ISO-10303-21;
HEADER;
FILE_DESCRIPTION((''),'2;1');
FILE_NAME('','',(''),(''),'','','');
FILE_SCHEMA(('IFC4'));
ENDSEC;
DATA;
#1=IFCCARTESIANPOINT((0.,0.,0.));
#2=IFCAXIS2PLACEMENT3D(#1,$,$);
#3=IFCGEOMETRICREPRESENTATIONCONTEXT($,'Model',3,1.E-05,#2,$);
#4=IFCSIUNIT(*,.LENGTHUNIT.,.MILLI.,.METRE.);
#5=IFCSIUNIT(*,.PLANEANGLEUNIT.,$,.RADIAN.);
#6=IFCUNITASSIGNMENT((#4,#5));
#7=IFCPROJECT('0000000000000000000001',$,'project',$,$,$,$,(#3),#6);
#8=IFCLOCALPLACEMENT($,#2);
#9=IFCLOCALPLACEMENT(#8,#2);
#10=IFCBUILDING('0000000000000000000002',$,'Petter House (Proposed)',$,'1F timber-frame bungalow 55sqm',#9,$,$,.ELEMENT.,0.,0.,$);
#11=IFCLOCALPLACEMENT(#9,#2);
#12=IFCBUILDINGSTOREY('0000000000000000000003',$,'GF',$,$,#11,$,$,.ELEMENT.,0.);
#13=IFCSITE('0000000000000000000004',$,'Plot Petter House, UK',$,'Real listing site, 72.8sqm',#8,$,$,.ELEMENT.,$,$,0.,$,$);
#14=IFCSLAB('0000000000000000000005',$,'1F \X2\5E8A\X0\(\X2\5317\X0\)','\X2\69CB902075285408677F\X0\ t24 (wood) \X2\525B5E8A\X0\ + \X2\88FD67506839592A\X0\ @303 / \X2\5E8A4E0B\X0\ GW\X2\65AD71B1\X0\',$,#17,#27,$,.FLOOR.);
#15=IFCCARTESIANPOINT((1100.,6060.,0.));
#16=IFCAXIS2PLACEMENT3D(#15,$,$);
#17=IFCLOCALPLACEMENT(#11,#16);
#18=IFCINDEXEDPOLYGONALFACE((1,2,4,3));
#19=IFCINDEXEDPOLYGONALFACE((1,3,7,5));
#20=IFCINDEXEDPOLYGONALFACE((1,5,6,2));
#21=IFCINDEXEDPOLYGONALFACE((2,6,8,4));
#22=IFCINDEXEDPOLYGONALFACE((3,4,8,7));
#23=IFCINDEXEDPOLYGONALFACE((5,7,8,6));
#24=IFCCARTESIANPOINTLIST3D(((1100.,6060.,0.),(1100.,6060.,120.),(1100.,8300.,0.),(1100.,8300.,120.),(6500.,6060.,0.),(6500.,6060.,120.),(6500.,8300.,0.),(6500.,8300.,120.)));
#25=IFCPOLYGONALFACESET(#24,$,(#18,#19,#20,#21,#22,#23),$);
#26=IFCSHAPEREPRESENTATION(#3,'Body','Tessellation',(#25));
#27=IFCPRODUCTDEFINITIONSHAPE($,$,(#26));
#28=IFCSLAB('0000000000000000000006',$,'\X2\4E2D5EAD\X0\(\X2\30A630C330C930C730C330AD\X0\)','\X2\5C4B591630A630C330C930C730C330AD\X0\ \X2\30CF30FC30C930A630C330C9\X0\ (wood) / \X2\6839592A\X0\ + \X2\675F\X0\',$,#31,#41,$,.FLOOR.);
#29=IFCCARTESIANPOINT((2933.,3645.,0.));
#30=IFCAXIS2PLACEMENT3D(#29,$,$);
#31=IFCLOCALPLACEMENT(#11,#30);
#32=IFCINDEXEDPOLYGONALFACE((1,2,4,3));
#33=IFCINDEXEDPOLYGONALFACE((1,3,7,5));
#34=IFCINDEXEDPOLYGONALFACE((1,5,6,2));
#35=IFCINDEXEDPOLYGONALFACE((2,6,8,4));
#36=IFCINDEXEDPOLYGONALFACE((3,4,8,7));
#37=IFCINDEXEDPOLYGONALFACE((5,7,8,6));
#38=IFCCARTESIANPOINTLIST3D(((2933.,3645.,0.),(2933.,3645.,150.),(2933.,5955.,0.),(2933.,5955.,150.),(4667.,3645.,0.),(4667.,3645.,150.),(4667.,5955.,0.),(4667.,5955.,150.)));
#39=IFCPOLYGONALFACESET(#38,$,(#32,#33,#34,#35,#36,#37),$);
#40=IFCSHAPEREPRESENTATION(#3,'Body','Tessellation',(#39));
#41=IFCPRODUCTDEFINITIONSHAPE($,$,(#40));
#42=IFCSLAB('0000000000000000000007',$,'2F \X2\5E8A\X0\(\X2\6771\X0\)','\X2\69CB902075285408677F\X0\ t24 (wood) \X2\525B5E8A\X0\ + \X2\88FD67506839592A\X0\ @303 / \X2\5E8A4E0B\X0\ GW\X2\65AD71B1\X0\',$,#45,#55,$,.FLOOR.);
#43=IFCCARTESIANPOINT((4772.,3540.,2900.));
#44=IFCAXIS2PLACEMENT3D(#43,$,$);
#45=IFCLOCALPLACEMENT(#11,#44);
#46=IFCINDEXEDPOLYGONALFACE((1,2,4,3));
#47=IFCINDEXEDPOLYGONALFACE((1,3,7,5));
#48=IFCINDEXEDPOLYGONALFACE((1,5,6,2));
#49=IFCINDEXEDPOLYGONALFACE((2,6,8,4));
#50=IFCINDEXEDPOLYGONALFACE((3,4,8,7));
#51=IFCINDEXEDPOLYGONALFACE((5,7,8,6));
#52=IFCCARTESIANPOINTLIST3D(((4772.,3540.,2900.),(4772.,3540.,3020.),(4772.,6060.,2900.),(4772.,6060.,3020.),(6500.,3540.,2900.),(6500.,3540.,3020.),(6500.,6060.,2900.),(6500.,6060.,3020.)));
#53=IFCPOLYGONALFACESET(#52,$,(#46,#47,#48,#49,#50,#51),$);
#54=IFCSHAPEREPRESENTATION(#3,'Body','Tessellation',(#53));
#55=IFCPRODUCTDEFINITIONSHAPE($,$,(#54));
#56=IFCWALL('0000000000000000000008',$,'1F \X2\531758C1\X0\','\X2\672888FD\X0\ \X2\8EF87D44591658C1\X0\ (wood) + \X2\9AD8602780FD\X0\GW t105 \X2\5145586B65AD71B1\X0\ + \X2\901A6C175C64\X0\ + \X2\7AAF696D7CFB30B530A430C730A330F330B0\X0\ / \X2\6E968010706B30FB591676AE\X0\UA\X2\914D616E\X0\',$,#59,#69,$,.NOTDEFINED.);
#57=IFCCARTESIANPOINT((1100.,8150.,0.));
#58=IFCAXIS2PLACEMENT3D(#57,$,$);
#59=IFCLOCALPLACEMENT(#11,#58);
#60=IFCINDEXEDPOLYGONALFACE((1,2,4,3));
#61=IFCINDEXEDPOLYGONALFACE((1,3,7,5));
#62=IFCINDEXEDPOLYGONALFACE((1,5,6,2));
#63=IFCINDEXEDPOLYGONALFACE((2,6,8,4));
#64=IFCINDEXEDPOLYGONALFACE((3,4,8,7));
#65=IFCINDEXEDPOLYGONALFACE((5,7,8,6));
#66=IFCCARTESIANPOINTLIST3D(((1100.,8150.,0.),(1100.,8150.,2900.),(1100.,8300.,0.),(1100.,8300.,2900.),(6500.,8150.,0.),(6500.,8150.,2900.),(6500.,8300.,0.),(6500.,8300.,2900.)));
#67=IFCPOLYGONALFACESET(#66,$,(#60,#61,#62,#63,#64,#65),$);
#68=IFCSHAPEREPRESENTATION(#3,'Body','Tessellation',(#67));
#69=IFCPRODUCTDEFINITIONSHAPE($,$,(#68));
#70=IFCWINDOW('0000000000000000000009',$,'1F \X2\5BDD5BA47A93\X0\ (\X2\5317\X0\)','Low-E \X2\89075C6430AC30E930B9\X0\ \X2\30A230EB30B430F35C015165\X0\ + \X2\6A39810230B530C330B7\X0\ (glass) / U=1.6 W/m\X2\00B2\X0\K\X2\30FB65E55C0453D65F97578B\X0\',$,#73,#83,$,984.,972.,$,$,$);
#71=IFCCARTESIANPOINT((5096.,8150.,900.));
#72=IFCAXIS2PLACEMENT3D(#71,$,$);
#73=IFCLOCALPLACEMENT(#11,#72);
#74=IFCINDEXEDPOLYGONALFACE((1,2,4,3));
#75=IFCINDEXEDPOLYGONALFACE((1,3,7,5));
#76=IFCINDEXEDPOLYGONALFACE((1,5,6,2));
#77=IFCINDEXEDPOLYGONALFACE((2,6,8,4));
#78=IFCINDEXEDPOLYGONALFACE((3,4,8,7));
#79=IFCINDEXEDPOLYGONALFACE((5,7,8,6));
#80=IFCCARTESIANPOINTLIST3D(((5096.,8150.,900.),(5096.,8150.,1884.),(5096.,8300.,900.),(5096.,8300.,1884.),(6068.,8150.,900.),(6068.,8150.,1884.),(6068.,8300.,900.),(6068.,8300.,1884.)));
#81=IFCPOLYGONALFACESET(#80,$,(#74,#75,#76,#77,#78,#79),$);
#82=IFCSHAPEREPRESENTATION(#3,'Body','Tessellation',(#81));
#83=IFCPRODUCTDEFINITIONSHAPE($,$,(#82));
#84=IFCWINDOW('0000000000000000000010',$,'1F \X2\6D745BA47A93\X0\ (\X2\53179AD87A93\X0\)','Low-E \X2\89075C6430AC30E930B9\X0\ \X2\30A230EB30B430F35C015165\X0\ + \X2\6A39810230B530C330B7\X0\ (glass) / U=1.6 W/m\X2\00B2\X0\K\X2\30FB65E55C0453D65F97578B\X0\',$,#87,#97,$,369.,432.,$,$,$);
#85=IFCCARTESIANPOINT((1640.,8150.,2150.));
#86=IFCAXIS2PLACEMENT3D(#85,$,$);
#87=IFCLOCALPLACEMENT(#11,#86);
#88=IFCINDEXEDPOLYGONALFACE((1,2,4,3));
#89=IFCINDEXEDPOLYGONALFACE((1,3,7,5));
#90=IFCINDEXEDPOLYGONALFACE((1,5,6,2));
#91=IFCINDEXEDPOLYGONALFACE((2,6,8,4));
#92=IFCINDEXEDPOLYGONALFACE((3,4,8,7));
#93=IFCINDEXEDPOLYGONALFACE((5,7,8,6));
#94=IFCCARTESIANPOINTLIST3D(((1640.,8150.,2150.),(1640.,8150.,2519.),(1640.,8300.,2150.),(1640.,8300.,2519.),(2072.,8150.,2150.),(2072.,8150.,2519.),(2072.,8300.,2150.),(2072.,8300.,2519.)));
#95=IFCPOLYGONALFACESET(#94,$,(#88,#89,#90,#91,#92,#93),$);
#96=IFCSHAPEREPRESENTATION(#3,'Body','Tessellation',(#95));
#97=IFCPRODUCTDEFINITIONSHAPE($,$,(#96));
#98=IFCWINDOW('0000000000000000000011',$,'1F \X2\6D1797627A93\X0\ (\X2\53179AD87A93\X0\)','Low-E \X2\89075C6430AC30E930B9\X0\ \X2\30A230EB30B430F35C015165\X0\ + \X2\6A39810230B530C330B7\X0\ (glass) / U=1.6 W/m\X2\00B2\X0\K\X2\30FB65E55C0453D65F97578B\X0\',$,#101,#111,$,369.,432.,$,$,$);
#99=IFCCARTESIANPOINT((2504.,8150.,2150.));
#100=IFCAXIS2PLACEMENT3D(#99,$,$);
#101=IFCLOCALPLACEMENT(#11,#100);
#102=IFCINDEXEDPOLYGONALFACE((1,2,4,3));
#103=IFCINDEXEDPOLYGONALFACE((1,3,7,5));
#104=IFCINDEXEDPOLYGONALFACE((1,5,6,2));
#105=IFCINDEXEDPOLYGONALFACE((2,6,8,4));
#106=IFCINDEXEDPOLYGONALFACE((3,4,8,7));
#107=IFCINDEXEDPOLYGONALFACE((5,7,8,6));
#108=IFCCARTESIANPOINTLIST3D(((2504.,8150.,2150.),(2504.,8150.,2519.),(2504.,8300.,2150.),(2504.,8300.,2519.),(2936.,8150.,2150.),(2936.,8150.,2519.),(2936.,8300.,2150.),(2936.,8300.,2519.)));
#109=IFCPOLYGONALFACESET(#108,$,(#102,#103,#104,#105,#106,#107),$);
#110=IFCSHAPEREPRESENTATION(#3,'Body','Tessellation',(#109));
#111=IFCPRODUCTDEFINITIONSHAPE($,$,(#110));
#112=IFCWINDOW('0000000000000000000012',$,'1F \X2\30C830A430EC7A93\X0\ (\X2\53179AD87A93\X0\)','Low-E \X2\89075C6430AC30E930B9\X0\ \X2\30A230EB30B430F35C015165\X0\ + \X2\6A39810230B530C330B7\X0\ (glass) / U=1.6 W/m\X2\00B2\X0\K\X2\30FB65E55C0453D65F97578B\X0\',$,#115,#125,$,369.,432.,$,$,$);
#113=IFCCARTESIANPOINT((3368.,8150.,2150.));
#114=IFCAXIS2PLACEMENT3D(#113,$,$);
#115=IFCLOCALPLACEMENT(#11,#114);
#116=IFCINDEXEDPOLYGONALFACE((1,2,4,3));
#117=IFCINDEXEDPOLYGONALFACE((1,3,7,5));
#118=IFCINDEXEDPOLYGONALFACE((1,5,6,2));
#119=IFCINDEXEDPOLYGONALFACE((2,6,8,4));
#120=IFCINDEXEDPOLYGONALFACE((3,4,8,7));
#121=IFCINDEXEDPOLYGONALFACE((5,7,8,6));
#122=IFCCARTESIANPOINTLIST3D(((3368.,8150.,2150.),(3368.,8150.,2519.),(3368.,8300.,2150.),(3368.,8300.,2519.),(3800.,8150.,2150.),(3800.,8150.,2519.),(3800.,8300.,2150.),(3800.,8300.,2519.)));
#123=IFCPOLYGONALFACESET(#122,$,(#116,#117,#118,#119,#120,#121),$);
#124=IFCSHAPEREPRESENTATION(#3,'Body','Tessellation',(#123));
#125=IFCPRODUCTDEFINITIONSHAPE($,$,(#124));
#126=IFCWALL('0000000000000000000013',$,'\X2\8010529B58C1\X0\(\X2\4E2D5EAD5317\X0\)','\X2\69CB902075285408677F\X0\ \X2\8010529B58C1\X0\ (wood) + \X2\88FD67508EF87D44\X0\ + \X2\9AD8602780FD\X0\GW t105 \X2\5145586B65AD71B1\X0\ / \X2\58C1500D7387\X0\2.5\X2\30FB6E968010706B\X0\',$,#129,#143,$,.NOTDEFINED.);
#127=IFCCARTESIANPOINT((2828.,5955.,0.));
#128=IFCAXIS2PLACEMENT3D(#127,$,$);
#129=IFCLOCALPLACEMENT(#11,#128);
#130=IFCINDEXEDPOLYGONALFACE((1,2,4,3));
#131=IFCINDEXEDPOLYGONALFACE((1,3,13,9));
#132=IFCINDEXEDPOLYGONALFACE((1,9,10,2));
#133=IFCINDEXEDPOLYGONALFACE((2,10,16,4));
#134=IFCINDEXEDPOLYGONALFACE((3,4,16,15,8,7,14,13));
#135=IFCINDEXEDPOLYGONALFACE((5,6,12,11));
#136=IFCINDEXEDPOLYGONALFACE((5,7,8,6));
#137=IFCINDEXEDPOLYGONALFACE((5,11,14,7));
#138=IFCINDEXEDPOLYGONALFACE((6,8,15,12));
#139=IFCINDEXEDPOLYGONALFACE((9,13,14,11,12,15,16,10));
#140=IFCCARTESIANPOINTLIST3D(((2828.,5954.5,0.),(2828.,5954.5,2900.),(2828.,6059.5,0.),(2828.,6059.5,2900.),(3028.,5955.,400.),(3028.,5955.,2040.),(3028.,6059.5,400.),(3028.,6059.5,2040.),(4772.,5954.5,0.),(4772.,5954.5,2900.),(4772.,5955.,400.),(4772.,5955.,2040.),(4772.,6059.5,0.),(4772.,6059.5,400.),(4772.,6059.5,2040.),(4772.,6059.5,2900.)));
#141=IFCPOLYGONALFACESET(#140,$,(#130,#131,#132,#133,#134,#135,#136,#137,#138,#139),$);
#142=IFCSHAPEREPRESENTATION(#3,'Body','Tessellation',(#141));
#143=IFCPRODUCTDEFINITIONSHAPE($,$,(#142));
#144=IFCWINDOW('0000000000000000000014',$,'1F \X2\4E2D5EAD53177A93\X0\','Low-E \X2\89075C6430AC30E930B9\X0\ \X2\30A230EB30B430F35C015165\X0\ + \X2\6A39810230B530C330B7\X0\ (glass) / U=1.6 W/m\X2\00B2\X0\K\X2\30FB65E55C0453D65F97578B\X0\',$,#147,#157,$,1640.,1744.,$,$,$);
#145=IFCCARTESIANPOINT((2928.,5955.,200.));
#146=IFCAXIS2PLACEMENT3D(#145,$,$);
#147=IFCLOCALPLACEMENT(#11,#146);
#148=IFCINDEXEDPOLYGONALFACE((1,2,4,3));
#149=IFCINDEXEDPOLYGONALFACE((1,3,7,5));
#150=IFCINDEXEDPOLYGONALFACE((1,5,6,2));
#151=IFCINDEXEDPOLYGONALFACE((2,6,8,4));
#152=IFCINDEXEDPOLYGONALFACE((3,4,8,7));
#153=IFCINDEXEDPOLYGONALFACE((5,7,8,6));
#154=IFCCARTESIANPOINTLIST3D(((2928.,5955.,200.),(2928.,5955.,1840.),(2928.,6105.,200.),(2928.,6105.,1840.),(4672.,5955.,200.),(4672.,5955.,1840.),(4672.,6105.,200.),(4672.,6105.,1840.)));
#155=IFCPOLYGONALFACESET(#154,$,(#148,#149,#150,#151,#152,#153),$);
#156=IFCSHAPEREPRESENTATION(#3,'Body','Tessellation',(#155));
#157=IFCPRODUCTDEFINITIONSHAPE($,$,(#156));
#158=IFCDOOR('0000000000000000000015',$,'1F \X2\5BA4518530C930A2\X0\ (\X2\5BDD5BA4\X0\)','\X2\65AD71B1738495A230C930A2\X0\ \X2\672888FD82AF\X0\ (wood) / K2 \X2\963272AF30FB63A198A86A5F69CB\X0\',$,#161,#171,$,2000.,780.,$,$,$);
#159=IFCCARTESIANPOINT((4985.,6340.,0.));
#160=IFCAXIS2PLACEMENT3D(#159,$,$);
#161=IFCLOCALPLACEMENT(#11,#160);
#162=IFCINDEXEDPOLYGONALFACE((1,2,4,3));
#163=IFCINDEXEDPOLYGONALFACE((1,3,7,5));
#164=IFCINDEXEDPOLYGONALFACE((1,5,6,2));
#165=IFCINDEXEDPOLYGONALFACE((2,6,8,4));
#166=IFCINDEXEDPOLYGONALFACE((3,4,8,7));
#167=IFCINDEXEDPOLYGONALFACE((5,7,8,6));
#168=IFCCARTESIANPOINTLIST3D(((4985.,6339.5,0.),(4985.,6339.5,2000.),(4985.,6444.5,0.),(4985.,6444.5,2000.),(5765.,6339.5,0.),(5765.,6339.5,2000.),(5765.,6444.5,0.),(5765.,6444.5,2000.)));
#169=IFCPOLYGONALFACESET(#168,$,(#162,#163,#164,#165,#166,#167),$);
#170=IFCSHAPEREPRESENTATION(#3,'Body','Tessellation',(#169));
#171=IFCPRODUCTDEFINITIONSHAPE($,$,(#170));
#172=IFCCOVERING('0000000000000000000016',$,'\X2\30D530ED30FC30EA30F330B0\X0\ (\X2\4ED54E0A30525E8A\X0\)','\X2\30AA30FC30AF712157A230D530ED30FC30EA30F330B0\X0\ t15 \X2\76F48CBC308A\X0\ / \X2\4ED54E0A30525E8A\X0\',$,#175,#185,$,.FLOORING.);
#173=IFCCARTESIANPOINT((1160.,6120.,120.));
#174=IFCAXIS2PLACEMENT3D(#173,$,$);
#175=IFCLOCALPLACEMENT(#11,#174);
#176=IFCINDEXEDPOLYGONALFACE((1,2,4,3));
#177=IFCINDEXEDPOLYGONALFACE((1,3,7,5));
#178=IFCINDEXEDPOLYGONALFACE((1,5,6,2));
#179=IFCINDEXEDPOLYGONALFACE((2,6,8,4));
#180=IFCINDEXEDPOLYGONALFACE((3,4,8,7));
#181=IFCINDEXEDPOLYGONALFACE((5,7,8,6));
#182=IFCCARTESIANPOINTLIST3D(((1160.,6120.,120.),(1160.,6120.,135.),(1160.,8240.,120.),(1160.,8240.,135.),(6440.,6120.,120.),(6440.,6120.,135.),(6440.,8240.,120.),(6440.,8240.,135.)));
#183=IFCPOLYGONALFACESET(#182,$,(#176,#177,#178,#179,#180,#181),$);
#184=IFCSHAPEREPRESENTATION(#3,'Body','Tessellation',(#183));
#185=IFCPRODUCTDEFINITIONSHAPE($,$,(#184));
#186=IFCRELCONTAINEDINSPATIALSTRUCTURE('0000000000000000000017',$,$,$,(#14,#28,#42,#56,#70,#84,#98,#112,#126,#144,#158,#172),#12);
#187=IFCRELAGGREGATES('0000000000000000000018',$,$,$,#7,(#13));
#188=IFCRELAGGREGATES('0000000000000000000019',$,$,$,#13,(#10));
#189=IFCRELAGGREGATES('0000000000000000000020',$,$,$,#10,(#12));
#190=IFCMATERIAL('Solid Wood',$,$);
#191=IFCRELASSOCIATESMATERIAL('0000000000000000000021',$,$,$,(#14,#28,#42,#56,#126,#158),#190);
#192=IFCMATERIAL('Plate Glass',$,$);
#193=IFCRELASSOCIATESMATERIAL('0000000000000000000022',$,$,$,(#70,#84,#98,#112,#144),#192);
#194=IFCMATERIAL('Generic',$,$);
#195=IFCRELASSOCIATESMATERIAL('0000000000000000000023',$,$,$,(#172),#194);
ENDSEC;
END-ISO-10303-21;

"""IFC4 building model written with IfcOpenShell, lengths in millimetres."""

from ifc_helpers import new_model, si_unit, frame, frame_2d, origin, place, context, project, spatial, rectangle, extrude, material, element, fill, save


model = new_model("IFC4")

# Units and contexts
model_context = context("Model", 3, precision=1e-05, world=origin())
ifc_project = project(units=[si_unit("LENGTHUNIT", "METRE", prefix="MILLI"), si_unit("PLANEANGLEUNIT", "RADIAN")], contexts=[model_context])

# Site, building, storey
site_placement = place(None, origin())
site = spatial("IfcSite", under=ifc_project, at=site_placement, Name="Plot Petter House, UK", ObjectType="Real listing site, 72.8sqm", CompositionType="ELEMENT", RefElevation=0.0)
building_placement = place(site_placement, origin())
building = spatial("IfcBuilding", under=site, at=building_placement, Name="Petter House (Proposed)", ObjectType="1F timber-frame bungalow 55sqm", CompositionType="ELEMENT", ElevationOfRefHeight=0.0, ElevationOfTerrain=0.0)
storey_placement = place(building_placement, origin())
storey = spatial("IfcBuildingStorey", under=building, at=storey_placement, Name="GF", CompositionType="ELEMENT", Elevation=0.0)

# Slabs
ifc_material_1 = material(Name="Solid Wood")
slab_1_placement = place(storey_placement, frame((1100.0, 6060.0, 0.0)))
element("IfcSlab", 1, at=slab_1_placement, inside=storey, material=ifc_material_1, Name="1F 床(北)", Description="構造用合板 t24 (wood) 剛床 + 製材根太 @303 / 床下 GW断熱", PredefinedType="FLOOR", context=model_context, shape_type="SweptSolid", body=[
    extrude(rectangle(XDim=5400.0, YDim=2240.0, at=frame_2d((2700.0, 1120.0))), frame((1100.0, 6060.0, 0.0)), (0.0, 0.0, 1.0), 120.0),
])
slab_2_placement = place(storey_placement, frame((2933.0, 3645.0, 0.0)))
element("IfcSlab", 2, at=slab_2_placement, inside=storey, material=ifc_material_1, Name="中庭(ウッドデッキ)", Description="屋外ウッドデッキ ハードウッド (wood) / 根太 + 束", PredefinedType="FLOOR", context=model_context, shape_type="SweptSolid", body=[
    extrude(rectangle(XDim=1734.0, YDim=2310.0, at=frame_2d((867.0, 1155.0))), frame((2933.0, 3645.0, 0.0)), (0.0, 0.0, 1.0), 150.0),
])
slab_3_placement = place(storey_placement, frame((4772.0, 3540.0, 2900.0)))
element("IfcSlab", 3, at=slab_3_placement, inside=storey, material=ifc_material_1, Name="2F 床(東)", Description="構造用合板 t24 (wood) 剛床 + 製材根太 @303 / 床下 GW断熱", PredefinedType="FLOOR", context=model_context, shape_type="SweptSolid", body=[
    extrude(rectangle(XDim=1728.0, YDim=2520.0, at=frame_2d((864.0, 1260.0))), frame((4772.0, 3540.0, 2900.0)), (0.0, 0.0, 1.0), 120.0),
])

# Wall, openings, windows
wall_1_placement = place(storey_placement, frame((1100.0, 8150.0, 0.0)))
wall_1 = element("IfcWall", 4, at=wall_1_placement, inside=storey, material=ifc_material_1, Name="1F 北壁", Description="木製 軸組外壁 (wood) + 高性能GW t105 充填断熱 + 通気層 + 窯業系サイディング / 準耐火・外皮UA配慮", PredefinedType="NOTDEFINED", context=model_context, shape_type="SweptSolid", body=[
    extrude(rectangle(XDim=5400.0, YDim=150.0, at=frame_2d((2700.0, 75.0))), frame((1100.0, 8150.0, 0.0)), (0.0, 0.0, 1.0), 2900.0),
])
opening_1_placement = place(storey_placement, frame((5096.0, 8150.0, 900.0)))
opening_1 = element("IfcOpeningElement", 5, at=opening_1_placement, cuts=wall_1, PredefinedType="NOTDEFINED", context=model_context, shape_type="SweptSolid", body=[
    extrude(rectangle(XDim=972.0, YDim=150.0, at=frame_2d((486.0, 75.0))), frame((5096.0, 8150.0, 900.0)), (0.0, 0.0, 1.0), 984.0),
])
opening_2_placement = place(storey_placement, frame((1640.0, 8150.0, 2150.0)))
opening_2 = element("IfcOpeningElement", 6, at=opening_2_placement, cuts=wall_1, PredefinedType="NOTDEFINED", context=model_context, shape_type="SweptSolid", body=[
    extrude(rectangle(XDim=432.0, YDim=150.0, at=frame_2d((216.0, 75.0))), frame((1640.0, 8150.0, 2150.0)), (0.0, 0.0, 1.0), 369.0),
])
opening_3_placement = place(storey_placement, frame((2504.0, 8150.0, 2150.0)))
opening_3 = element("IfcOpeningElement", 7, at=opening_3_placement, cuts=wall_1, PredefinedType="NOTDEFINED", context=model_context, shape_type="SweptSolid", body=[
    extrude(rectangle(XDim=432.0, YDim=150.0, at=frame_2d((216.0, 75.0))), frame((2504.0, 8150.0, 2150.0)), (0.0, 0.0, 1.0), 369.0),
])
opening_4_placement = place(storey_placement, frame((3368.0, 8150.0, 2150.0)))
opening_4 = element("IfcOpeningElement", 8, at=opening_4_placement, cuts=wall_1, PredefinedType="NOTDEFINED", context=model_context, shape_type="SweptSolid", body=[
    extrude(rectangle(XDim=432.0, YDim=150.0, at=frame_2d((216.0, 75.0))), frame((3368.0, 8150.0, 2150.0)), (0.0, 0.0, 1.0), 369.0),
])
ifc_material_2 = material(Name="Plate Glass")
window_1_placement = place(storey_placement, frame((5096.0, 8150.0, 900.0)))
window_1 = element("IfcWindow", 9, at=window_1_placement, inside=storey, material=ifc_material_2, Name="1F 寝室窓 (北)", Description="Low-E 複層ガラス アルゴン封入 + 樹脂サッシ (glass) / U=1.6 W/m²K・日射取得型", OverallHeight=984.0, OverallWidth=972.0, context=model_context, shape_type="SweptSolid", body=[
    extrude(rectangle(XDim=972.0, YDim=150.0, at=frame_2d((486.0, 75.0))), frame((5096.0, 8150.0, 900.0)), (0.0, 0.0, 1.0), 984.0),
])
fill(opening_1, window_1)
window_2_placement = place(storey_placement, frame((1640.0, 8150.0, 2150.0)))
window_2 = element("IfcWindow", 10, at=window_2_placement, inside=storey, material=ifc_material_2, Name="1F 浴室窓 (北高窓)", Description="Low-E 複層ガラス アルゴン封入 + 樹脂サッシ (glass) / U=1.6 W/m²K・日射取得型", OverallHeight=369.0, OverallWidth=432.0, context=model_context, shape_type="SweptSolid", body=[
    extrude(rectangle(XDim=432.0, YDim=150.0, at=frame_2d((216.0, 75.0))), frame((1640.0, 8150.0, 2150.0)), (0.0, 0.0, 1.0), 369.0),
])
fill(opening_2, window_2)
window_3_placement = place(storey_placement, frame((2504.0, 8150.0, 2150.0)))
window_3 = element("IfcWindow", 11, at=window_3_placement, inside=storey, material=ifc_material_2, Name="1F 洗面窓 (北高窓)", Description="Low-E 複層ガラス アルゴン封入 + 樹脂サッシ (glass) / U=1.6 W/m²K・日射取得型", OverallHeight=369.0, OverallWidth=432.0, context=model_context, shape_type="SweptSolid", body=[
    extrude(rectangle(XDim=432.0, YDim=150.0, at=frame_2d((216.0, 75.0))), frame((2504.0, 8150.0, 2150.0)), (0.0, 0.0, 1.0), 369.0),
])
fill(opening_3, window_3)
window_4_placement = place(storey_placement, frame((3368.0, 8150.0, 2150.0)))
window_4 = element("IfcWindow", 12, at=window_4_placement, inside=storey, material=ifc_material_2, Name="1F トイレ窓 (北高窓)", Description="Low-E 複層ガラス アルゴン封入 + 樹脂サッシ (glass) / U=1.6 W/m²K・日射取得型", OverallHeight=369.0, OverallWidth=432.0, context=model_context, shape_type="SweptSolid", body=[
    extrude(rectangle(XDim=432.0, YDim=150.0, at=frame_2d((216.0, 75.0))), frame((3368.0, 8150.0, 2150.0)), (0.0, 0.0, 1.0), 369.0),
])
fill(opening_4, window_4)

# Wall, opening, window
wall_2_placement = place(storey_placement, frame((2828.0, 5955.0, 0.0)))
wall_2 = element("IfcWall", 13, at=wall_2_placement, inside=storey, material=ifc_material_1, Name="耐力壁(中庭北)", Description="構造用合板 耐力壁 (wood) + 製材軸組 + 高性能GW t105 充填断熱 / 壁倍率2.5・準耐火", PredefinedType="NOTDEFINED", context=model_context, shape_type="SweptSolid", body=[
    extrude(rectangle(XDim=1944.0, YDim=105.0, at=frame_2d((972.0, 52.0))), frame((2828.0, 5955.0, 0.0)), (0.0, 0.0, 1.0), 2900.0),
])
opening_5_placement = place(storey_placement, frame((2928.0, 5955.0, 200.0)))
opening_5 = element("IfcOpeningElement", 14, at=opening_5_placement, cuts=wall_2, PredefinedType="NOTDEFINED", context=model_context, shape_type="SweptSolid", body=[
    extrude(rectangle(XDim=1744.0, YDim=150.0, at=frame_2d((872.0, 75.0))), frame((2928.0, 5955.0, 200.0)), (0.0, 0.0, 1.0), 1640.0),
])
window_5_placement = place(storey_placement, frame((2928.0, 5955.0, 200.0)))
window_5 = element("IfcWindow", 15, at=window_5_placement, inside=storey, material=ifc_material_2, Name="1F 中庭北窓", Description="Low-E 複層ガラス アルゴン封入 + 樹脂サッシ (glass) / U=1.6 W/m²K・日射取得型", OverallHeight=1640.0, OverallWidth=1744.0, context=model_context, shape_type="SweptSolid", body=[
    extrude(rectangle(XDim=1744.0, YDim=150.0, at=frame_2d((872.0, 75.0))), frame((2928.0, 5955.0, 200.0)), (0.0, 0.0, 1.0), 1640.0),
])
fill(opening_5, window_5)

# Door
door_1_placement = place(storey_placement, frame((4985.0, 6340.0, 0.0)))
element("IfcDoor", 16, at=door_1_placement, inside=storey, material=ifc_material_1, Name="1F 室内ドア (寝室)", Description="断熱玄関ドア 木製芯 (wood) / K2 防犯・採風機構", OverallHeight=2000.0, OverallWidth=780.0, context=model_context, shape_type="SweptSolid", body=[
    extrude(rectangle(XDim=780.0, YDim=105.0, at=frame_2d((390.0, 52.0))), frame((4985.0, 6340.0, 0.0)), (0.0, 0.0, 1.0), 2000.0),
])

# Covering
ifc_material_3 = material(Name="Generic")
covering_1_placement = place(storey_placement, frame((1160.0, 6120.0, 120.0)))
element("IfcCovering", 17, at=covering_1_placement, inside=storey, material=ifc_material_3, Name="フローリング (仕上げ床)", Description="オーク無垢フローリング t15 直貼り / 仕上げ床", PredefinedType="FLOORING", context=model_context, shape_type="SweptSolid", body=[
    extrude(rectangle(XDim=5280.0, YDim=2120.0, at=frame_2d((2640.0, 1060.0))), frame((1160.0, 6120.0, 120.0)), (0.0, 0.0, 1.0), 15.0),
])

save(model, "model.ifc")
